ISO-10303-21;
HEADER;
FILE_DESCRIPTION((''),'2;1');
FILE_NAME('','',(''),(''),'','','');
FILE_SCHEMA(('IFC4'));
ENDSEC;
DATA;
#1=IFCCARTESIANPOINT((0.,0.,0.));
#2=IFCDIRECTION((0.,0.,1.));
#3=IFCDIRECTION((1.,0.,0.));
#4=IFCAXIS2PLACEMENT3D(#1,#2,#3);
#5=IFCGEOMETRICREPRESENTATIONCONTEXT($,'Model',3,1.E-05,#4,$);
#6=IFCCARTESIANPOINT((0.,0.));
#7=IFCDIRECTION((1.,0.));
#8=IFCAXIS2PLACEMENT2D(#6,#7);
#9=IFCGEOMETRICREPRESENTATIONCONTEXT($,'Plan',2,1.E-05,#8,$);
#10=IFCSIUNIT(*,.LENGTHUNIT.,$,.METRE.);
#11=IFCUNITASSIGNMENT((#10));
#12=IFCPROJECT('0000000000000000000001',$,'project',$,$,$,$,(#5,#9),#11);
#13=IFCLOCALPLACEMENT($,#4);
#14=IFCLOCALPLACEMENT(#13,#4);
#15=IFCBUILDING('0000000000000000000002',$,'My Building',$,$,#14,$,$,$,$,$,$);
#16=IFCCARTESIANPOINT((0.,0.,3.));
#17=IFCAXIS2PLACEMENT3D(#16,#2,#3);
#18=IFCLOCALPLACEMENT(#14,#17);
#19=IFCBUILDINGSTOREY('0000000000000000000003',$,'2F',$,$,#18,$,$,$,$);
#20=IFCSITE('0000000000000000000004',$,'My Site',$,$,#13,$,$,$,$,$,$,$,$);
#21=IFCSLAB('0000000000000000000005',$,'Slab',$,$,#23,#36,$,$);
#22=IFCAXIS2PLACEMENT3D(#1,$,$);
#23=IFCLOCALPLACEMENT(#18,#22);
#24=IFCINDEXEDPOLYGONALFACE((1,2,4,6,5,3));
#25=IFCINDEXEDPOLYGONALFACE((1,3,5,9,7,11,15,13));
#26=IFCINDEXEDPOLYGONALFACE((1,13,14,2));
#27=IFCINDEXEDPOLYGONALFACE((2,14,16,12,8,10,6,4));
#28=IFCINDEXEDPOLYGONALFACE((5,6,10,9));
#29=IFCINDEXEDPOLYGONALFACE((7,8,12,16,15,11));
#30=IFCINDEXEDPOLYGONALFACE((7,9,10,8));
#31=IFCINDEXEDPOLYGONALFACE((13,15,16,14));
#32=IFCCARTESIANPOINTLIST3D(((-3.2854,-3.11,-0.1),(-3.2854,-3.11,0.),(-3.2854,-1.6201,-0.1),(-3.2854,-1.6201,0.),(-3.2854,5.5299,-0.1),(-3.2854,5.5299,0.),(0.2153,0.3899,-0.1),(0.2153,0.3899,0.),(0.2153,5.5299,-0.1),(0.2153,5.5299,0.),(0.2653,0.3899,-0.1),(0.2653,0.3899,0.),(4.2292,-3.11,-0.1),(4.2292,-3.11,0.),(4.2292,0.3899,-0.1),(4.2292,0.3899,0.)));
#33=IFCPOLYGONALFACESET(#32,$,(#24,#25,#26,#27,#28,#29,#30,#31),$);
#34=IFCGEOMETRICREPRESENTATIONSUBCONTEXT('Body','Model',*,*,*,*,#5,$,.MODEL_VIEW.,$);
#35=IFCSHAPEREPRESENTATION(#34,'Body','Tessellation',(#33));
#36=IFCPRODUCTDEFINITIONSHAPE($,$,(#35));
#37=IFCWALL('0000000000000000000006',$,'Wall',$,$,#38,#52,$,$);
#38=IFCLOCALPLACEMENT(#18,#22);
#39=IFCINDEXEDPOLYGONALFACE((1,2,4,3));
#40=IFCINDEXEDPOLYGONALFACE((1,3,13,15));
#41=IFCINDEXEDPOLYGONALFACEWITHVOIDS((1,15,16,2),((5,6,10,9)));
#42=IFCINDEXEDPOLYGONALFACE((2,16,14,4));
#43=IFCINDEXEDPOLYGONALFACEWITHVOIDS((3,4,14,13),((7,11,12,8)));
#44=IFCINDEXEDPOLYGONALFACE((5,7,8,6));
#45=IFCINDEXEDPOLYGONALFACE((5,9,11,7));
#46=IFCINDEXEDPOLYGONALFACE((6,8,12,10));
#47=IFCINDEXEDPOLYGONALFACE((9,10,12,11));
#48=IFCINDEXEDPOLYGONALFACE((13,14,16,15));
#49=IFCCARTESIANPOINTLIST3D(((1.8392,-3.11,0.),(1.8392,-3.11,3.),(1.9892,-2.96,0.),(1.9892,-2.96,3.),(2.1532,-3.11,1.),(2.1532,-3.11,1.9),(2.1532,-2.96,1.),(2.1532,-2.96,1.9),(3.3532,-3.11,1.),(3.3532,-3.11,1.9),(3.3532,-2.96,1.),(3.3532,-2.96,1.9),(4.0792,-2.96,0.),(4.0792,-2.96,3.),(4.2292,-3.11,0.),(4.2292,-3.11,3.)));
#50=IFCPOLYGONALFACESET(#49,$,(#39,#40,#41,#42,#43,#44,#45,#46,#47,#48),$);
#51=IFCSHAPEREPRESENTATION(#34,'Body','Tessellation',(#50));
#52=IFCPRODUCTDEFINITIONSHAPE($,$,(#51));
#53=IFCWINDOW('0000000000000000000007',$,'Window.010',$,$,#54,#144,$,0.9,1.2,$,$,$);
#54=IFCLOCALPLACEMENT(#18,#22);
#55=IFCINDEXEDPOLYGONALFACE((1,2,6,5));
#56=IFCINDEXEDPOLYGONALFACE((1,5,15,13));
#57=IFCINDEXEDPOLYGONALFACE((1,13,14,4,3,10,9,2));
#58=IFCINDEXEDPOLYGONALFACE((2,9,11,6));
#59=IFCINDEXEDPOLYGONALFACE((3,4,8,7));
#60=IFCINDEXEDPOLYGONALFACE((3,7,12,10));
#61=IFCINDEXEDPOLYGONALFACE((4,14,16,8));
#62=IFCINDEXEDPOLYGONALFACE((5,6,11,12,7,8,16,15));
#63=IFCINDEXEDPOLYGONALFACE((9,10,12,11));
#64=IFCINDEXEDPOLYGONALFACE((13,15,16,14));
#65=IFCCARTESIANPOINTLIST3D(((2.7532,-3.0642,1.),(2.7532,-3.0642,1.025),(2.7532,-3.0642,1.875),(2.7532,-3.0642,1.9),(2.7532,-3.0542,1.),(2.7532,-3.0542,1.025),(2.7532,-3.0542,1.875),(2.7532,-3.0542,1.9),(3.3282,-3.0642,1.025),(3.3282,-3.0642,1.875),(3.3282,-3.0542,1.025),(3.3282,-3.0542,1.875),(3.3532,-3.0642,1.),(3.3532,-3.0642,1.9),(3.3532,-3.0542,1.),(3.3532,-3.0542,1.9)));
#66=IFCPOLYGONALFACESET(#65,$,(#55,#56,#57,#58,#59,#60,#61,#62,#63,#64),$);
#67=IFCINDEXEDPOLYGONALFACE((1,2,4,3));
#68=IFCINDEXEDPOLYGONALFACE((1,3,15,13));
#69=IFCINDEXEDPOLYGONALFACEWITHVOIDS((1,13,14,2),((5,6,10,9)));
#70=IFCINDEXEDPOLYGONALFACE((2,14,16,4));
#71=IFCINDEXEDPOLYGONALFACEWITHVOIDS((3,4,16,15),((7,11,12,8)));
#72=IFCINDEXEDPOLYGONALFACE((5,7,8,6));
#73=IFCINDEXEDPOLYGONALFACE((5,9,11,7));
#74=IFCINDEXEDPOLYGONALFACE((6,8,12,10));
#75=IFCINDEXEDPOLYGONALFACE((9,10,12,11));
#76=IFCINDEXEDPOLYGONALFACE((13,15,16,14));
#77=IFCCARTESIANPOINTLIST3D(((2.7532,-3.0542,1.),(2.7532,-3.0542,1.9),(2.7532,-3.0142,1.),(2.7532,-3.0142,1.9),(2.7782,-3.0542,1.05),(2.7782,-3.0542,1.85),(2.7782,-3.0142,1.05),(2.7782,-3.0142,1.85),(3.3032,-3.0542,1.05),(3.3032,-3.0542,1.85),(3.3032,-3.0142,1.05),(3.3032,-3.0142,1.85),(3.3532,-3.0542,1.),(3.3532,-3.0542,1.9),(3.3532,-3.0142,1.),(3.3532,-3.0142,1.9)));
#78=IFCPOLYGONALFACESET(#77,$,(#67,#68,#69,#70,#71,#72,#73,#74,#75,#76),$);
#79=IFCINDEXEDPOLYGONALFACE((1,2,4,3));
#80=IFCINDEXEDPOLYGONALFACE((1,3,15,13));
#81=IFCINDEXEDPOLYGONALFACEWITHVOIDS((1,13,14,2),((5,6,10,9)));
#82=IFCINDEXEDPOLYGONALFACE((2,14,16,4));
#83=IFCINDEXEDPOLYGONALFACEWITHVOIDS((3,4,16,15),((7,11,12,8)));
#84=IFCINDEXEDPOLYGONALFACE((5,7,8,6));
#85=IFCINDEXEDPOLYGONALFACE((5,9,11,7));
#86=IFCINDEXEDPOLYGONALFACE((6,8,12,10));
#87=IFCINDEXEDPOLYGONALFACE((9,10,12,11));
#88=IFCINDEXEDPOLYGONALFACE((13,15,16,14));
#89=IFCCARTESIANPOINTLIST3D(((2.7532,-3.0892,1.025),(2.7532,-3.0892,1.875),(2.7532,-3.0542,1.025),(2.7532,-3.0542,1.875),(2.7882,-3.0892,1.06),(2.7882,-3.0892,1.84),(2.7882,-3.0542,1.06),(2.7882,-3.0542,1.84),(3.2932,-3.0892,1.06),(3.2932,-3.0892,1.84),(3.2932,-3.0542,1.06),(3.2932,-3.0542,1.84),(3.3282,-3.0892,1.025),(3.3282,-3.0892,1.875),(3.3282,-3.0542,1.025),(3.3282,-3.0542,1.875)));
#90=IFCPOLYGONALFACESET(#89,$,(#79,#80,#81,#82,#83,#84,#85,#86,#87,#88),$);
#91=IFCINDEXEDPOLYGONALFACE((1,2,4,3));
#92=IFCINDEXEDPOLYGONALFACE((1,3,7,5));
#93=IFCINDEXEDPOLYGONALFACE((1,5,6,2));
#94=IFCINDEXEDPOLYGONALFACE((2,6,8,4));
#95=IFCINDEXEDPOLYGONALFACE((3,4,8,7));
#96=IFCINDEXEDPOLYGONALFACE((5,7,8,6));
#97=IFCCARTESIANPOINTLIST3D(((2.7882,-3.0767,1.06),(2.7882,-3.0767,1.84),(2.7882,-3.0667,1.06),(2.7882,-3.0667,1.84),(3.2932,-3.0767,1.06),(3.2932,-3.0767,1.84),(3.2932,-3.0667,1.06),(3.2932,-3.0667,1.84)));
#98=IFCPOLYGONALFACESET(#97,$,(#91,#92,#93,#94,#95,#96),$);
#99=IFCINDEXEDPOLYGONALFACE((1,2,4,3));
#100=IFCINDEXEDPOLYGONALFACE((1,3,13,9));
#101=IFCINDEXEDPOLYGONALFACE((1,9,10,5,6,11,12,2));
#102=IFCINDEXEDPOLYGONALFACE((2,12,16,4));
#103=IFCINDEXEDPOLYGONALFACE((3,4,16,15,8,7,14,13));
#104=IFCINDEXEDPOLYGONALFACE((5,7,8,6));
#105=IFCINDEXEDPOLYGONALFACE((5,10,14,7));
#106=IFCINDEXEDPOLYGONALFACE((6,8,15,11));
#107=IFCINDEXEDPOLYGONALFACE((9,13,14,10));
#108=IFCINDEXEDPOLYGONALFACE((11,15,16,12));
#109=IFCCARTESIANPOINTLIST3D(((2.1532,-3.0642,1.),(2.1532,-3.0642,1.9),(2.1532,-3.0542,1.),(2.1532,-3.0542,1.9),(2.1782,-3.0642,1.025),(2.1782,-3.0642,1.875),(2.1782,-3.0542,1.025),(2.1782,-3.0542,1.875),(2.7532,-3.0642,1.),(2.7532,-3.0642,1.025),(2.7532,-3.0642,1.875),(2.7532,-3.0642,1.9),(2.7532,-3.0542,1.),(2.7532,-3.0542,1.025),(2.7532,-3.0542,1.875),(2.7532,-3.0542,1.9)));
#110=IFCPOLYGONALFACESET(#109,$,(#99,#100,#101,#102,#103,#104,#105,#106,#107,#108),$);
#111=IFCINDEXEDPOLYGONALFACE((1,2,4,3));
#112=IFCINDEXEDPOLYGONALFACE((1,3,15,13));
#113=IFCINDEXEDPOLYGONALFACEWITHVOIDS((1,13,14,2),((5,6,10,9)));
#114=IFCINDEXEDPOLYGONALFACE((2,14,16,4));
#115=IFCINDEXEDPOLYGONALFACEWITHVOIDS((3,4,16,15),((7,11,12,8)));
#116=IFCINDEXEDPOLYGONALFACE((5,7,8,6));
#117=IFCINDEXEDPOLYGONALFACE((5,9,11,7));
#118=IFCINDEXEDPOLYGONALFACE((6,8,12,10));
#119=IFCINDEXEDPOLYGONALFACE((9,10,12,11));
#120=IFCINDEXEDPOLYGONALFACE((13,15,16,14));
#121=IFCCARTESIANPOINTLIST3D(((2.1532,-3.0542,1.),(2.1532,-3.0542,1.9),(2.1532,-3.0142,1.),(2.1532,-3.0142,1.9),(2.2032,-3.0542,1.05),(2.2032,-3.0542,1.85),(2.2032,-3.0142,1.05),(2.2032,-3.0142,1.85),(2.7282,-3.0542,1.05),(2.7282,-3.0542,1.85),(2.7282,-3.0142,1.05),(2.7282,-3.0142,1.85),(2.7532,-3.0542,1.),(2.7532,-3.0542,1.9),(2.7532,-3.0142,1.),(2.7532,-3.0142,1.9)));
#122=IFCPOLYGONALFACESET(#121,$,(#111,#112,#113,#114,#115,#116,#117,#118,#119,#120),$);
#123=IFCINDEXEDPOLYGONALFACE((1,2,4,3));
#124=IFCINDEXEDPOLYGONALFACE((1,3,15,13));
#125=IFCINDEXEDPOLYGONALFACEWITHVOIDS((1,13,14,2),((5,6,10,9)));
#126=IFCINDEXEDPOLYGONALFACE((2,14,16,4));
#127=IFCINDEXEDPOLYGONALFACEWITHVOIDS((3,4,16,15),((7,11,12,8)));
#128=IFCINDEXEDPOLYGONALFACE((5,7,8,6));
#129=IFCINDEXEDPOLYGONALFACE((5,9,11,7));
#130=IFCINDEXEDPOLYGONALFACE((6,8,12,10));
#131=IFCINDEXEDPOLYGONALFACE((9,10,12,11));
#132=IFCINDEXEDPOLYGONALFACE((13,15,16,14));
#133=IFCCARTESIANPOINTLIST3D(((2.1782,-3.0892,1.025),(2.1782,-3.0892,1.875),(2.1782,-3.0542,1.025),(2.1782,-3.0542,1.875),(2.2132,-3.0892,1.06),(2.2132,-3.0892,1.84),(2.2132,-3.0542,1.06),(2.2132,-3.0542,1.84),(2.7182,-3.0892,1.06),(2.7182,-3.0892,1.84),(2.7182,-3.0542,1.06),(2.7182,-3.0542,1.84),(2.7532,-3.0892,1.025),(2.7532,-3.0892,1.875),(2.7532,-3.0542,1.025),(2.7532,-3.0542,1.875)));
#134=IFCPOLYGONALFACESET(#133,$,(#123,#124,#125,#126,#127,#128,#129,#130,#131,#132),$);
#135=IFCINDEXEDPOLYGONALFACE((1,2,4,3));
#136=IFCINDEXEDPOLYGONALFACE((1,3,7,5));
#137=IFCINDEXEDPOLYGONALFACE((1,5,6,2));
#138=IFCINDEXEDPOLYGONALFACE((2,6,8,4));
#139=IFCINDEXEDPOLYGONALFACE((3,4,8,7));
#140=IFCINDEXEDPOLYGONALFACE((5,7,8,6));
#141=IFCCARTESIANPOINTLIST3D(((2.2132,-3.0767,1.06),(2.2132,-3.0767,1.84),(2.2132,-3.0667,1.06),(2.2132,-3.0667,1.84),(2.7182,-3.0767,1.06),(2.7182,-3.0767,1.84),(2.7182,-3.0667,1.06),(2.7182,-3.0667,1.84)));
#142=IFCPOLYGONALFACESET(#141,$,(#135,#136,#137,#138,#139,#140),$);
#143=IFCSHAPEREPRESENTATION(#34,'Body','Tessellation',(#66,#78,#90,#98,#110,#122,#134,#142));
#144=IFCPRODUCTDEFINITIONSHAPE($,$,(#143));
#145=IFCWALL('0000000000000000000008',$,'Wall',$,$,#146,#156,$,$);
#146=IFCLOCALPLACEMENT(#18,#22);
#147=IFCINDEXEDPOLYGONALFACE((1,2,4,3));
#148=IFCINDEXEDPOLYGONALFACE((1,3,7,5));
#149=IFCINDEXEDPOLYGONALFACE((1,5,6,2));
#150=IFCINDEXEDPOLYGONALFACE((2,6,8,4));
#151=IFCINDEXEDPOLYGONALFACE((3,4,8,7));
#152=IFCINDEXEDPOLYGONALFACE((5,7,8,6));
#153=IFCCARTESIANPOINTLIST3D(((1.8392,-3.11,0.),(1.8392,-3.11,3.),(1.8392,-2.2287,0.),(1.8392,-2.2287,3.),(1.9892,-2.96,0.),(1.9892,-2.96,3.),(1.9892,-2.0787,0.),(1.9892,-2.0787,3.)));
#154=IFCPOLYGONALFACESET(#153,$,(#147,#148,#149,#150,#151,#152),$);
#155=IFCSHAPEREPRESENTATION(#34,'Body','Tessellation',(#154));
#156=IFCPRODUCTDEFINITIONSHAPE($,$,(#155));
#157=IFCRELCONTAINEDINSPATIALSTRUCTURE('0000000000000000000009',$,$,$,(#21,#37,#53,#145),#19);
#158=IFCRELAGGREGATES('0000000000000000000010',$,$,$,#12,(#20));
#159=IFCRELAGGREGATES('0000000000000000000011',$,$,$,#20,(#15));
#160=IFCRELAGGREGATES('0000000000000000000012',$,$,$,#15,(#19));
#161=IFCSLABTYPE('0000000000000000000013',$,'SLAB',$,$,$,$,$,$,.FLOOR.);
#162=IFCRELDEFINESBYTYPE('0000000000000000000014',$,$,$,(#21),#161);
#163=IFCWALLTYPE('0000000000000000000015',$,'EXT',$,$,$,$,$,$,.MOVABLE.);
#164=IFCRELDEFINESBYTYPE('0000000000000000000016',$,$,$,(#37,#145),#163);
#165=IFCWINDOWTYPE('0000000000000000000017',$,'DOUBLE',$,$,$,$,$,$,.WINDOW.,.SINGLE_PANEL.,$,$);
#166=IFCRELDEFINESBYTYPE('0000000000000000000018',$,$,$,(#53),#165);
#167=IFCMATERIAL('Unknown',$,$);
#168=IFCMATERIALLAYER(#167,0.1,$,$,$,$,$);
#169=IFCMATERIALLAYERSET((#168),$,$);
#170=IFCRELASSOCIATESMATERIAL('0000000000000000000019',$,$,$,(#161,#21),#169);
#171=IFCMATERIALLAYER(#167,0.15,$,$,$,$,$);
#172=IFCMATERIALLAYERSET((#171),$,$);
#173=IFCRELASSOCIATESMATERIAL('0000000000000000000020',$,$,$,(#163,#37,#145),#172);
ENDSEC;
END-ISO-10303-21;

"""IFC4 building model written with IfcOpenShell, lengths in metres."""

from ifc_helpers import new_model, entity, si_unit, frame, origin_with_axes, origin_2d_with_axis, place, context, subcontext, project, spatial, line, indexed_curve, outline, extrude, shape, source, transform, mapped, material, layer, layer_set, layer_usage, type_object, type_shapes, element, fill, save


model = new_model("IFC4")

# Units and contexts
model_context = context("Model", 3, precision=1e-05, world=origin_with_axes())
plan_context = context("Plan", 2, precision=1e-05, world=origin_2d_with_axis())
body_context_1 = subcontext(model_context, "Body", "Model", "MODEL_VIEW")
body_context_2 = subcontext(plan_context, "Body", "Plan", "PLAN_VIEW")
ifc_project = project(units=[si_unit("LENGTHUNIT", "METRE")], contexts=[model_context, plan_context])

# Site, building, storey
site_placement = place(None, origin_with_axes())
site = spatial("IfcSite", under=ifc_project, at=site_placement, Name="My Site")
building_placement = place(site_placement, origin_with_axes())
building = spatial("IfcBuilding", under=site, at=building_placement, Name="My Building")
storey_placement = place(building_placement, frame((0.0, 0.0, 3.0), z_axis=(0.0, 0.0, 1.0), x_axis=(1.0, 0.0, 0.0)))
storey = spatial("IfcBuildingStorey", under=building, at=storey_placement, Name="2F")

# Slab
ifc_material = material(Name="Unknown")
ifc_layer_1 = layer(ifc_material, 0.1)
ifc_layer_set_1 = layer_set([ifc_layer_1])
ifc_layer_usage_1 = layer_usage(ifc_layer_set_1, "AXIS3", "POSITIVE", -0.1)
slab_type = type_object("IfcSlabType", Name="SLAB", PredefinedType="FLOOR", material=ifc_layer_set_1)
slab_placement = place(storey_placement, frame((-3.2854, -1.6201, 0.0), z_axis=(0.0, 0.0, 1.0), x_axis=(1.0, 0.0, 0.0)))
element("IfcSlab", 1, at=slab_placement, inside=storey, type_object=slab_type, material=ifc_layer_usage_1, Name="Slab", context=body_context_1, shape_type="SweptSolid", body=[
    extrude(outline(indexed_curve([(0.0, 0.0), (0.0, -1.4899), (7.5146, -1.4899), (7.5146, 2.01), (3.5507, 2.01), (3.5007, 2.01), (3.5007, 7.15), (0.0, 7.15), (0.0, 0.0)])), frame((0.0, 0.0, -0.1), z_axis=(0.0, 0.0, 1.0), x_axis=(1.0, 0.0, 0.0)), (0.0, 0.0, 1.0), 0.1),
])

# Wall, opening, window
ifc_layer_2 = layer(ifc_material, 0.15)
ifc_layer_set_2 = layer_set([ifc_layer_2])
ifc_layer_usage_2 = layer_usage(ifc_layer_set_2, "AXIS2", "POSITIVE", -0.15)
wall_type_1 = type_object("IfcWallType", Name="EXT", PredefinedType="MOVABLE", material=ifc_layer_set_2)
wall_1_placement = place(storey_placement, frame((4.2292, -3.11, 0.0), z_axis=(0.0, 0.0, 1.0), x_axis=(-1.0, 0.0, 0.0)))
wall_1 = element("IfcWall", 2, at=wall_1_placement, inside=storey, type_object=wall_type_1, material=ifc_layer_usage_2, Name="Wall", context=body_context_1, shape_type="SweptSolid", body=[
    extrude(outline(indexed_curve([(0.15, -0.15), (0.0, 0.0), (2.39, 0.0), (2.24, -0.15)], segments=[line(1, 2, 3, 4, 1)])), origin_with_axes(), (0.0, 0.0, 1.0), 3.0),
])
placement_1 = place(storey_placement, frame((3.3532, -2.9642, 1.0), z_axis=(0.0, 0.0, 1.0), x_axis=(-1.0, 0.000001, 0.0)))
opening_1 = element("IfcOpeningElement", 3, at=placement_1, cuts=wall_1, PredefinedType="OPENING", context=body_context_1, shape_type="SweptSolid", body=[
    extrude(outline(indexed_curve([(0.0, 0.0), (1.2, 0.0), (1.2, 0.9), (0.0, 0.9)], segments=[line(1, 2, 3, 4, 1)])), frame((0.0, -0.6, 0.0), z_axis=(0.0, -1.0, 0.0), x_axis=(1.0, 0.0, 0.0)), (0.0, 0.0, -1.0), 1.2),
])
window_type_1 = type_object("IfcWindowType", Name="DOUBLE", PartitioningType="SINGLE_PANEL", PredefinedType="WINDOW")
shared_shape_1 = source(origin_with_axes(), body_context_1, "Body", "SweptSolid", [
    extrude(outline(indexed_curve([(0.6, 0.0), (0.0, 0.0), (0.0, 0.9), (0.6, 0.9), (0.6, 0.875), (0.025, 0.875), (0.025, 0.025), (0.6, 0.025)], segments=[line(1, 2, 3, 4, 5, 6, 7, 8, 1)])), frame((0.0, 0.09, 0.0), z_axis=(0.0, -1.0, 0.0), x_axis=(1.0, 0.0, 0.0)), (0.0, 0.0, -1.0), 0.01),
    extrude(outline(indexed_curve([(0.0, 0.0), (0.6, 0.0), (0.6, 0.9), (0.0, 0.9)], segments=[line(1, 2, 3, 4, 1)]), holes=[indexed_curve([(0.05, 0.05), (0.575, 0.05), (0.575, 0.85), (0.05, 0.85)], segments=[line(1, 2, 3, 4, 1)])]), frame((0.0, 0.05, 0.0), z_axis=(0.0, -1.0, 0.0), x_axis=(1.0, 0.0, 0.0)), (0.0, 0.0, -1.0), 0.04),
    extrude(outline(indexed_curve([(0.0, 0.0), (0.575, 0.0), (0.575, 0.85), (0.0, 0.85)], segments=[line(1, 2, 3, 4, 1)]), holes=[indexed_curve([(0.035, 0.035), (0.54, 0.035), (0.54, 0.815), (0.035, 0.815)], segments=[line(1, 2, 3, 4, 1)])]), frame((0.025, 0.09, 0.025), z_axis=(0.0, -1.0, 0.0), x_axis=(1.0, 0.0, 0.0)), (0.0, 0.0, -1.0), 0.035),
    extrude(outline(indexed_curve([(0.035, 0.035), (0.54, 0.035), (0.54, 0.815), (0.035, 0.815)], segments=[line(1, 2, 3, 4, 1)])), frame((0.025, 0.1025, 0.025), z_axis=(0.0, -1.0, 0.0), x_axis=(1.0, 0.0, 0.0)), (0.0, 0.0, -1.0), 0.01),
    extrude(outline(indexed_curve([(0.0, 0.9), (0.6, 0.9), (0.6, 0.0), (0.0, 0.0), (0.0, 0.025), (0.575, 0.025), (0.575, 0.875), (0.0, 0.875)], segments=[line(1, 2, 3, 4, 5, 6, 7, 8, 1)])), frame((0.6, 0.09, 0.0), z_axis=(0.0, -1.0, 0.0), x_axis=(1.0, 0.0, 0.0)), (0.0, 0.0, -1.0), 0.01),
    extrude(outline(indexed_curve([(0.0, 0.0), (0.6, 0.0), (0.6, 0.9), (0.0, 0.9)], segments=[line(1, 2, 3, 4, 1)]), holes=[indexed_curve([(0.025, 0.05), (0.55, 0.05), (0.55, 0.85), (0.025, 0.85)], segments=[line(1, 2, 3, 4, 1)])]), frame((0.6, 0.05, 0.0), z_axis=(0.0, -1.0, 0.0), x_axis=(1.0, 0.0, 0.0)), (0.0, 0.0, -1.0), 0.04),
    extrude(outline(indexed_curve([(0.0, 0.0), (0.575, 0.0), (0.575, 0.85), (0.0, 0.85)], segments=[line(1, 2, 3, 4, 1)]), holes=[indexed_curve([(0.035, 0.035), (0.54, 0.035), (0.54, 0.815), (0.035, 0.815)], segments=[line(1, 2, 3, 4, 1)])]), frame((0.6, 0.09, 0.025), z_axis=(0.0, -1.0, 0.0), x_axis=(1.0, 0.0, 0.0)), (0.0, 0.0, -1.0), 0.035),
    extrude(outline(indexed_curve([(0.035, 0.815), (0.54, 0.815), (0.54, 0.035), (0.035, 0.035), (0.035, 0.815)])), frame((0.6, 0.1025, 0.025), z_axis=(0.0, -1.0, 0.0), x_axis=(1.0, 0.0, 0.0)), (0.0, 0.0, -1.0), 0.01),
])
shared_shape_2 = source(origin_with_axes(), body_context_2, "Body", "Curve2D", [
    entity("IfcIndexedPolyCurve", entity("IfcCartesianPointList2D", [[0.05, 0.05], [0.575, 0.05]])),
    entity("IfcIndexedPolyCurve", entity("IfcCartesianPointList2D", [[0.0, 0.1], [0.025, 0.1], [0.025, 0.09], [0.05, 0.09], [0.05, 0.05], [0.0, 0.05]]), [entity("IfcLineIndex", [1, 2, 3, 4, 5, 6, 1])]),
    entity("IfcIndexedPolyCurve", entity("IfcCartesianPointList2D", [[0.6, 0.1], [0.6, 0.1], [0.6, 0.09], [0.575, 0.09], [0.575, 0.05], [0.6, 0.05]])),
    entity("IfcIndexedPolyCurve", entity("IfcCartesianPointList2D", [[0.025, 0.09], [0.06, 0.09], [0.06, 0.125], [0.025, 0.125]]), [entity("IfcLineIndex", [1, 2, 3, 4, 1])]),
    entity("IfcIndexedPolyCurve", entity("IfcCartesianPointList2D", [[0.6, 0.09], [0.565, 0.09], [0.565, 0.125], [0.6, 0.125]]), [entity("IfcLineIndex", [1, 2, 3, 4, 1])]),
    entity("IfcIndexedPolyCurve", entity("IfcCartesianPointList2D", [[0.06, 0.09], [0.565, 0.09]])),
    entity("IfcIndexedPolyCurve", entity("IfcCartesianPointList2D", [[0.06, 0.125], [0.565, 0.125]])),
    entity("IfcIndexedPolyCurve", entity("IfcCartesianPointList2D", [[0.06, 0.1075], [0.565, 0.1075]])),
    entity("IfcIndexedPolyCurve", entity("IfcCartesianPointList2D", [[0.625, 0.05], [1.15, 0.05]])),
    entity("IfcIndexedPolyCurve", entity("IfcCartesianPointList2D", [[0.6, 0.1], [0.6, 0.1], [0.6, 0.09], [0.625, 0.09], [0.625, 0.05], [0.6, 0.05]])),
    entity("IfcIndexedPolyCurve", entity("IfcCartesianPointList2D", [[1.2, 0.1], [1.175, 0.1], [1.175, 0.09], [1.15, 0.09], [1.15, 0.05], [1.2, 0.05]]), [entity("IfcLineIndex", [1, 2, 3, 4, 5, 6, 1])]),
    entity("IfcIndexedPolyCurve", entity("IfcCartesianPointList2D", [[0.6, 0.09], [0.635, 0.09], [0.635, 0.125], [0.6, 0.125]]), [entity("IfcLineIndex", [1, 2, 3, 4, 1])]),
    entity("IfcIndexedPolyCurve", entity("IfcCartesianPointList2D", [[1.175, 0.09], [1.14, 0.09], [1.14, 0.125], [1.175, 0.125]]), [entity("IfcLineIndex", [1, 2, 3, 4, 1])]),
    entity("IfcIndexedPolyCurve", entity("IfcCartesianPointList2D", [[0.635, 0.09], [1.14, 0.09]])),
    entity("IfcIndexedPolyCurve", entity("IfcCartesianPointList2D", [[0.635, 0.125], [1.14, 0.125]])),
    entity("IfcIndexedPolyCurve", entity("IfcCartesianPointList2D", [[0.635, 0.1075], [1.14, 0.1075]])),
])
type_shapes(window_type_1, [shared_shape_1, shared_shape_2])
window_1 = element("IfcWindow", 4, at=placement_1, inside=storey, type_object=window_type_1, Name="Window.010", OverallHeight=0.9, OverallWidth=1.2, shapes=[
    shape(body_context_1, "Body", "MappedRepresentation", [mapped(shared_shape_1, transform((0.0, 0.0, 0.0), x_axis=(1.0, 0.0, 0.0), y_axis=(0.0, 1.0, 0.0), z_axis=(0.0, 0.0, 1.0), scale=1.0))]),
    shape(body_context_2, "Body", "MappedRepresentation", [mapped(shared_shape_2, transform((0.0, 0.0, 0.0), x_axis=(1.0, 0.0, 0.0), y_axis=(0.0, 1.0, 0.0), z_axis=(0.0, 0.0, 1.0), scale=1.0))]),
])
fill(opening_1, window_1)

# Wall
ifc_layer_usage_3 = layer_usage(ifc_layer_set_2, "AXIS2", "POSITIVE", -0.15)
wall_2_placement = place(storey_placement, frame((1.8392, -3.11, 0.0), z_axis=(0.0, 0.0, 1.0), x_axis=(0.0, 1.0, 0.0)))
element("IfcWall", 5, at=wall_2_placement, inside=storey, type_object=wall_type_1, material=ifc_layer_usage_3, Name="Wall", context=body_context_1, shape_type="SweptSolid", body=[
    extrude(outline(indexed_curve([(0.15, -0.15), (0.0, 0.0), (0.8813, 0.0), (1.0313, -0.15)], segments=[line(1, 2, 3, 4, 1)])), origin_with_axes(), (0.0, 0.0, 1.0), 3.0),
])

save(model, "model.ifc")
